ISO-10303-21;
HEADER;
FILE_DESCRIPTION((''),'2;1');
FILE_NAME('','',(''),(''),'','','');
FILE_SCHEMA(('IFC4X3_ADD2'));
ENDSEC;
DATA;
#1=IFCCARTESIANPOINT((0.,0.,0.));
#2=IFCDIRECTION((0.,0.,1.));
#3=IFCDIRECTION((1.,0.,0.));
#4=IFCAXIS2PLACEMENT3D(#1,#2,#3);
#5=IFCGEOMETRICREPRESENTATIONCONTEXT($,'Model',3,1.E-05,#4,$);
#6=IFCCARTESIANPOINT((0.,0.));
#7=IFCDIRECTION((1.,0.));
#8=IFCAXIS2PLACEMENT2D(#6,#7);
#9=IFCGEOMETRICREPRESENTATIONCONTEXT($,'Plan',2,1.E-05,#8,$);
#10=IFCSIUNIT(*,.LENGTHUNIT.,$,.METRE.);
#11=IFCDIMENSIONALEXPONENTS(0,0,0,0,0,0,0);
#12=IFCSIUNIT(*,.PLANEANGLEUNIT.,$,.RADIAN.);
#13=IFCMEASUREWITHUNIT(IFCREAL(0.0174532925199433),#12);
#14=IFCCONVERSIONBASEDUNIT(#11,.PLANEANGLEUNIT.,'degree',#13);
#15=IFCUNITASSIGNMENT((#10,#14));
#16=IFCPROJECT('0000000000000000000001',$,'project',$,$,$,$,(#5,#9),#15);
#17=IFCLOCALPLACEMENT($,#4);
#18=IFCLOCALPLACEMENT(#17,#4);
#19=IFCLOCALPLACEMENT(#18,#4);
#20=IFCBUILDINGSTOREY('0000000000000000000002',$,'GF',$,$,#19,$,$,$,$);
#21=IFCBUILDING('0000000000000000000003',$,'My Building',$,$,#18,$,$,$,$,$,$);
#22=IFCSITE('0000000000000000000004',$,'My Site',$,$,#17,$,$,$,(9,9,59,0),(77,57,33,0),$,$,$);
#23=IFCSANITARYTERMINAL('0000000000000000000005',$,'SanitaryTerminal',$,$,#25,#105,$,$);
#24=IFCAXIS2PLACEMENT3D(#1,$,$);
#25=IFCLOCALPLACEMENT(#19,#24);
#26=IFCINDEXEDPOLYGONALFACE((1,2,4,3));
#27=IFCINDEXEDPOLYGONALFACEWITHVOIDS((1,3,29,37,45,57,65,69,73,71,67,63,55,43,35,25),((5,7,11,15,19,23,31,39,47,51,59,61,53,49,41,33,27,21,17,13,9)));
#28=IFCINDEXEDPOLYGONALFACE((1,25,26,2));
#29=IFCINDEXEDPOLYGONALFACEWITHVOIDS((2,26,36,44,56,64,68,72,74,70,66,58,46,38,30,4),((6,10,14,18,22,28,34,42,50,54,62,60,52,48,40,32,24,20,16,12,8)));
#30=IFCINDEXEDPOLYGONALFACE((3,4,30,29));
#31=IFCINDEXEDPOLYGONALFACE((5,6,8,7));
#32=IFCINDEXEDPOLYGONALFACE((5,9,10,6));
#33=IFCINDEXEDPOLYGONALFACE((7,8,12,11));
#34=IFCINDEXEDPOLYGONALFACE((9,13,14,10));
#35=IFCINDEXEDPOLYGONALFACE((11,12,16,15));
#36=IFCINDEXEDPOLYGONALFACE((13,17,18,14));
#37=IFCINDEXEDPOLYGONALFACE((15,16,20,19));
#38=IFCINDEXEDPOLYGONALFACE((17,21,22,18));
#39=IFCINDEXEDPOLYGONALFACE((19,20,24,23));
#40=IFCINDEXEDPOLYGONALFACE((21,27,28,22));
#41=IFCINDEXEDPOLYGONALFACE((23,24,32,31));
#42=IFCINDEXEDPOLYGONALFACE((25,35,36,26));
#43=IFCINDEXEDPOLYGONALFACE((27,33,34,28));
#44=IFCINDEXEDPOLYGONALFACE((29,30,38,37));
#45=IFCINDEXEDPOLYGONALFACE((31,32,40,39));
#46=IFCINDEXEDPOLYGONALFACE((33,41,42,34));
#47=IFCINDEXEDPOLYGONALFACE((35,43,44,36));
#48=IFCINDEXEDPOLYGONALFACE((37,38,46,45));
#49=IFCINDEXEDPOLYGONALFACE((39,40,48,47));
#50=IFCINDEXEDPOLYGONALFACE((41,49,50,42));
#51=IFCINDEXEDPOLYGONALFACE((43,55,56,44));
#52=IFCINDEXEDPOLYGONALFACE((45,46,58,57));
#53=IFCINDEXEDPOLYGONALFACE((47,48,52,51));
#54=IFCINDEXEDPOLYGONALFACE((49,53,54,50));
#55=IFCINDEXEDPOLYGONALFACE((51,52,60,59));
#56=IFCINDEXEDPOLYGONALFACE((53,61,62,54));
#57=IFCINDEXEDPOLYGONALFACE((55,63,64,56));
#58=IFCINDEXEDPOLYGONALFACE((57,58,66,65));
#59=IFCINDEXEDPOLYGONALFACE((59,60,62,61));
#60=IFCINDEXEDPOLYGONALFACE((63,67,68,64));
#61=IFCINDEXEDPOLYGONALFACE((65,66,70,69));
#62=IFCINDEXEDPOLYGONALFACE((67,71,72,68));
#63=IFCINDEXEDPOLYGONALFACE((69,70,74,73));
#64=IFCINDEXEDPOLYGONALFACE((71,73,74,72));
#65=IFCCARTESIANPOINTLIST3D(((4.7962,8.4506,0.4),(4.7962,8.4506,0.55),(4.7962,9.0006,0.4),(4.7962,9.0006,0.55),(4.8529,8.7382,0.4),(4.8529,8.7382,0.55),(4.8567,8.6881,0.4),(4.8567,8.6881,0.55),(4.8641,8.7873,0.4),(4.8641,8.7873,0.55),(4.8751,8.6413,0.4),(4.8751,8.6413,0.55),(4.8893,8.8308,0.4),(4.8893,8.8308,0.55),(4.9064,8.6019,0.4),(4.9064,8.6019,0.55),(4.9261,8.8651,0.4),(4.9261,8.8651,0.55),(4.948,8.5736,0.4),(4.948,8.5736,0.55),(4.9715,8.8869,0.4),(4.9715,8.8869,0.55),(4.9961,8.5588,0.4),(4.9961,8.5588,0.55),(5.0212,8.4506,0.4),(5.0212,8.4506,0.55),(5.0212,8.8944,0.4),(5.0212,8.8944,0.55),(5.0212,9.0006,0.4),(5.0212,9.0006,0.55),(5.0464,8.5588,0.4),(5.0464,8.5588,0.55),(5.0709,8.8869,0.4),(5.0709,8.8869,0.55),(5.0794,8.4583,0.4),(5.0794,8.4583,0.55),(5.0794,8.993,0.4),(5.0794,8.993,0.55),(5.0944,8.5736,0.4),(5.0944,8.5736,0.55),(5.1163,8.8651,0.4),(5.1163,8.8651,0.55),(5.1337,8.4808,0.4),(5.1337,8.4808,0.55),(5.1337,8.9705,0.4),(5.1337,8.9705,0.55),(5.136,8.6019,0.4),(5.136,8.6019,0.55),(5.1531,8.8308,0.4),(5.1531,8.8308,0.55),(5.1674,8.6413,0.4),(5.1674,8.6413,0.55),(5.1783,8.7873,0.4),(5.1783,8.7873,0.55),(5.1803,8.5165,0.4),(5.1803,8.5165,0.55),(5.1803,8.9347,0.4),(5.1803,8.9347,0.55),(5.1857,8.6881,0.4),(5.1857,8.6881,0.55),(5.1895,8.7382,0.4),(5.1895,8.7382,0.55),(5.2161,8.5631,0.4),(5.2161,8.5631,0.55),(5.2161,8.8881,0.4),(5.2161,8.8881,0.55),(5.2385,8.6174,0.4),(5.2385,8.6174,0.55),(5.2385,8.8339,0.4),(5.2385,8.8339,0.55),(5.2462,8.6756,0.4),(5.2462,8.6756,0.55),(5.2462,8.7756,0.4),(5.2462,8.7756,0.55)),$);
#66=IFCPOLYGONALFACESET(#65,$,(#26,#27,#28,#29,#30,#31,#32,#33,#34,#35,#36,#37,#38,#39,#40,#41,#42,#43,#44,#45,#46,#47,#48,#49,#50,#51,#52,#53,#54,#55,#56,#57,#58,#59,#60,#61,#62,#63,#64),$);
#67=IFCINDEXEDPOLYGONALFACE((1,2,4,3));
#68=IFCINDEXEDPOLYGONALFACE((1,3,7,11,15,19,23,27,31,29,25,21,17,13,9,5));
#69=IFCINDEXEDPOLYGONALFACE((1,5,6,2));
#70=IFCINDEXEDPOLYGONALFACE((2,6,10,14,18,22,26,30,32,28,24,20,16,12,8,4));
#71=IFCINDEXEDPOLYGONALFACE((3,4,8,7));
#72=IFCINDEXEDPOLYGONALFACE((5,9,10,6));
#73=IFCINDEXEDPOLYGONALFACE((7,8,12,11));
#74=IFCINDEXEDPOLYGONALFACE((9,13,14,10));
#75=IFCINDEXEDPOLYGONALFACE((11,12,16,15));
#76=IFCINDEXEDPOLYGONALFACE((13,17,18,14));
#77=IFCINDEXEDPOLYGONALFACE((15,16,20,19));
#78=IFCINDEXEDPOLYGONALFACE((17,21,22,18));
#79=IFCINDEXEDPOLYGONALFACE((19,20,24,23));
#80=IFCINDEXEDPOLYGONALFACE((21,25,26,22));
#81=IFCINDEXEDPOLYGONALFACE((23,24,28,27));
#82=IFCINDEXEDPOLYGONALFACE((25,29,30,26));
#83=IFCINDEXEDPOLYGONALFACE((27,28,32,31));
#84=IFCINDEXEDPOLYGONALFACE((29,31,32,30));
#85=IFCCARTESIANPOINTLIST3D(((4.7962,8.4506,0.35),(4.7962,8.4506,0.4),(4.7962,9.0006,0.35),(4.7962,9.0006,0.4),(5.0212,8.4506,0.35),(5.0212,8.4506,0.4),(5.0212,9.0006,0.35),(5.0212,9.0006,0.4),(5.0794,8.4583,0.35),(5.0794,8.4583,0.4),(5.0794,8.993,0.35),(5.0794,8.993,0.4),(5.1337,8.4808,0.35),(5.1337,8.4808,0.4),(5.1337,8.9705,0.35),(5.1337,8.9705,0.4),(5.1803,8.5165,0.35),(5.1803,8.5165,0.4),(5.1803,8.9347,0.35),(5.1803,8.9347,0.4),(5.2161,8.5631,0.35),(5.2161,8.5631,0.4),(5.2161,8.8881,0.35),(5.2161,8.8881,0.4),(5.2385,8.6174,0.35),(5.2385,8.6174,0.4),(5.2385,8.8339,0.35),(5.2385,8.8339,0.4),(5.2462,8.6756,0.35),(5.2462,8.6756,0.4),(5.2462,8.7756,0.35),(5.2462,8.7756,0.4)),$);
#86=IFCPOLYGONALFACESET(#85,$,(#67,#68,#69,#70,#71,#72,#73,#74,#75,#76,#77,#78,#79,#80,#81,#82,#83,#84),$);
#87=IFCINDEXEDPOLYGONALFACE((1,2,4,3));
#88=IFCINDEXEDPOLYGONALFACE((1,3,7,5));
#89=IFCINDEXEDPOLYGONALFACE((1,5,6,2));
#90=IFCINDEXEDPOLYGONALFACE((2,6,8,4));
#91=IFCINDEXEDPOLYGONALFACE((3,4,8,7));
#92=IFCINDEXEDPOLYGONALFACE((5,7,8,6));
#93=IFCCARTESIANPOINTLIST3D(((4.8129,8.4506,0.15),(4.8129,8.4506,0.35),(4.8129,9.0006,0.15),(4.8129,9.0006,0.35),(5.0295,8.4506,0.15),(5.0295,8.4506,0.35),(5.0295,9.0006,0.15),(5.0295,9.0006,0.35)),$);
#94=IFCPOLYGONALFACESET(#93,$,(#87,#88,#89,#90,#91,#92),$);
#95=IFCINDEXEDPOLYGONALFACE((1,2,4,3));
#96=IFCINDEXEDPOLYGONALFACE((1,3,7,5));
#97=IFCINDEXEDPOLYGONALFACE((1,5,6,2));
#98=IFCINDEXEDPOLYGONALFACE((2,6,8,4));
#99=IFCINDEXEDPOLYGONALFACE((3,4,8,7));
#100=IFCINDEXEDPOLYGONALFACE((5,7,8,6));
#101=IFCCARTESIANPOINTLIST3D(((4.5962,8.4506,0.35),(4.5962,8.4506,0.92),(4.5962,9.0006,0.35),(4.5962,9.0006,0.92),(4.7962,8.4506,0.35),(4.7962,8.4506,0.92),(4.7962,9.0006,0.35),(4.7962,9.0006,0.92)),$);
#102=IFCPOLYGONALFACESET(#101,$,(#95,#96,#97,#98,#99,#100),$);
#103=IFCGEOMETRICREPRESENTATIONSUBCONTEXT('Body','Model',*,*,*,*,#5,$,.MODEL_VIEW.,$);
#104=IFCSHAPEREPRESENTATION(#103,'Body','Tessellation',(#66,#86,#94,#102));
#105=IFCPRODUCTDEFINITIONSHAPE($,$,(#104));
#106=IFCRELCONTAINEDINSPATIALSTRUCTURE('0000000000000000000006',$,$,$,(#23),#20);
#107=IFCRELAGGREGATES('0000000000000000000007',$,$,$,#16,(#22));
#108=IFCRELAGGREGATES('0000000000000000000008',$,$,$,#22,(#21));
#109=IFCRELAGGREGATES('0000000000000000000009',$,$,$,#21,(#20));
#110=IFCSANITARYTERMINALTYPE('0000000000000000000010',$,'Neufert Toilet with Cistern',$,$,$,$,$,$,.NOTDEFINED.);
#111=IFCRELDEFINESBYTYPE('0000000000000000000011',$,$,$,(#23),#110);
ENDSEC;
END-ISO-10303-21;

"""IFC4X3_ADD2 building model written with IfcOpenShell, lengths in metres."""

from ifc_helpers import new_model, entity, si_unit, converted_unit, frame, frame_2d, origin_with_axes, origin_2d_with_axis, place, context, subcontext, project, spatial, line, arc, indexed_curve, circle_curve, outline, extrude, shape, source, transform, mapped, type_object, type_shapes, element, save


model = new_model("IFC4X3_ADD2")

# Units and contexts
model_context = context("Model", 3, precision=1e-05, world=origin_with_axes())
plan_context = context("Plan", 2, precision=1e-05, world=origin_2d_with_axis())
body_context_1 = subcontext(model_context, "Body", "Model", "MODEL_VIEW")
body_context_2 = subcontext(plan_context, "Body", "Plan", "PLAN_VIEW")
ifc_project = project(units=[si_unit("LENGTHUNIT", "METRE"), converted_unit("PLANEANGLEUNIT", "degree", entity("IfcReal", 0.0174532925199433), si_unit("PLANEANGLEUNIT", "RADIAN"), dimensions=[0, 0, 0, 0, 0, 0, 0])], contexts=[model_context, plan_context])

# Site, building, storey
site_placement = place(None, origin_with_axes())
site = spatial("IfcSite", under=ifc_project, at=site_placement, Name="My Site", RefLatitude=(9, 9, 59, 0), RefLongitude=(77, 57, 33, 0))
building_placement = place(site_placement, origin_with_axes())
building = spatial("IfcBuilding", under=site, at=building_placement, Name="My Building")
storey_placement = place(building_placement, origin_with_axes())
storey = spatial("IfcBuildingStorey", under=building, at=storey_placement, Name="GF")

# Sanitary terminal
sanitary_terminal_type_1 = type_object("IfcSanitaryTerminalType", Name="Neufert Toilet with Cistern", PredefinedType="NOTDEFINED")
shared_shape_1 = source(origin_with_axes(), body_context_1, "Body", "SweptSolid", [
    extrude(outline(indexed_curve([(-0.275, -0.2), (0.275, -0.2), (0.275, -0.425), (0.2091, -0.5841), (0.05, -0.65), (-0.05, -0.65), (-0.2091, -0.5841), (-0.275, -0.425), (0.0, -0.5938), (0.0, -0.2563)], segments=[arc(8, 7, 6), line(6, 5), arc(5, 4, 3), line(3, 2), line(2, 1), line(1, 8)], self_intersect=False), holes=[circle_curve(frame_2d((0.0, -0.425)), 0.1687)]), frame((0.0, 0.0, 0.25), z_axis=(0.0, 0.0, 1.0), x_axis=(1.0, 0.0, 0.0)), (0.0, 0.0, 1.0), 0.15),
    extrude(outline(indexed_curve([(-0.275, -0.2), (0.275, -0.2), (0.275, -0.425), (0.2091, -0.5841), (0.05, -0.65), (-0.05, -0.65), (-0.2091, -0.5841), (-0.275, -0.425)], segments=[line(1, 2), line(2, 3), arc(3, 4, 5), line(5, 6), arc(6, 7, 8), line(8, 1)])), frame((0.0, 0.0, 0.2), z_axis=(0.0, 0.0, 1.0), x_axis=(1.0, 0.0, 0.0)), (0.0, 0.0, 1.0), 0.05),
    extrude(outline(indexed_curve([(-0.275, -0.2167), (0.275, -0.2167), (0.275, -0.4333), (-0.275, -0.4333)], segments=[line(1, 2, 3, 4, 1)])), origin_with_axes(), (0.0, 0.0, 1.0), 0.2),
    extrude(outline(indexed_curve([(-0.275, 0.0), (0.275, 0.0), (0.275, -0.2), (-0.275, -0.2)], segments=[line(1, 2, 3, 4, 1)])), frame((0.0, 0.0, 0.2), z_axis=(0.0, 0.0, 1.0), x_axis=(1.0, 0.0, 0.0)), (0.0, 0.0, 1.0), 0.57),
])
shared_shape_2 = source(origin_with_axes(), body_context_2, "Body", "Curve2D", [
    entity("IfcIndexedPolyCurve", entity("IfcCartesianPointList2D", [[-0.275, 0.0], [0.275, 0.0], [0.275, -0.2], [-0.275, -0.2]]), [entity("IfcLineIndex", [1, 2, 3, 4, 1])]),
    entity("IfcIndexedPolyCurve", entity("IfcCartesianPointList2D", [[0.165, -0.2], [0.1925, -0.335]])),
    entity("IfcTrimmedCurve", entity("IfcEllipse", entity("IfcAxis2Placement2D", entity("IfcCartesianPoint", [0.0, -0.335]), entity("IfcDirection", [1.0, 0.0])), 0.1925, 0.315), [entity("IfcCartesianPoint", [-0.1925, -0.335])], [entity("IfcCartesianPoint", [0.1925, -0.335])], True, "CARTESIAN"),
    entity("IfcIndexedPolyCurve", entity("IfcCartesianPointList2D", [[-0.165, -0.2], [-0.1925, -0.335]])),
    entity("IfcEllipse", entity("IfcAxis2Placement2D", entity("IfcCartesianPoint", [0.0, -0.452]), entity("IfcDirection", [1.0, 0.0])), 0.1313, 0.1575),
    entity("IfcIndexedPolyCurve", entity("IfcCartesianPointList2D", [[-0.0344, -0.452], [-0.0344, -0.4295], [0.0344, -0.4295], [0.0344, -0.452]])),
    entity("IfcTrimmedCurve", entity("IfcEllipse", entity("IfcAxis2Placement2D", entity("IfcCartesianPoint", [0.0, -0.452]), entity("IfcDirection", [1.0, 0.0])), 0.0344, 0.0225), [entity("IfcCartesianPoint", [-0.0344, -0.452])], [entity("IfcCartesianPoint", [0.0344, -0.452])], True, "CARTESIAN"),
])
type_shapes(sanitary_terminal_type_1, [shared_shape_1, shared_shape_2])
sanitary_terminal_1_placement = place(storey_placement, frame((4.5962, 8.7256, 0.15), z_axis=(0.0, 0.0, 1.0), x_axis=(0.0, 1.0, 0.0)))
element("IfcSanitaryTerminal", 1, at=sanitary_terminal_1_placement, inside=storey, type_object=sanitary_terminal_type_1, Name="SanitaryTerminal", shapes=[
    shape(body_context_1, "Body", "MappedRepresentation", [mapped(shared_shape_1, transform((0.0, 0.0, 0.0), x_axis=(1.0, 0.0, 0.0), y_axis=(0.0, 1.0, 0.0), z_axis=(0.0, 0.0, 1.0), scale=1.0))]),
    shape(body_context_2, "Body", "MappedRepresentation", [mapped(shared_shape_2, transform((0.0, 0.0, 0.0), x_axis=(1.0, 0.0, 0.0), y_axis=(0.0, 1.0, 0.0), z_axis=(0.0, 0.0, 1.0), scale=1.0))]),
])

save(model, "model.ifc")
